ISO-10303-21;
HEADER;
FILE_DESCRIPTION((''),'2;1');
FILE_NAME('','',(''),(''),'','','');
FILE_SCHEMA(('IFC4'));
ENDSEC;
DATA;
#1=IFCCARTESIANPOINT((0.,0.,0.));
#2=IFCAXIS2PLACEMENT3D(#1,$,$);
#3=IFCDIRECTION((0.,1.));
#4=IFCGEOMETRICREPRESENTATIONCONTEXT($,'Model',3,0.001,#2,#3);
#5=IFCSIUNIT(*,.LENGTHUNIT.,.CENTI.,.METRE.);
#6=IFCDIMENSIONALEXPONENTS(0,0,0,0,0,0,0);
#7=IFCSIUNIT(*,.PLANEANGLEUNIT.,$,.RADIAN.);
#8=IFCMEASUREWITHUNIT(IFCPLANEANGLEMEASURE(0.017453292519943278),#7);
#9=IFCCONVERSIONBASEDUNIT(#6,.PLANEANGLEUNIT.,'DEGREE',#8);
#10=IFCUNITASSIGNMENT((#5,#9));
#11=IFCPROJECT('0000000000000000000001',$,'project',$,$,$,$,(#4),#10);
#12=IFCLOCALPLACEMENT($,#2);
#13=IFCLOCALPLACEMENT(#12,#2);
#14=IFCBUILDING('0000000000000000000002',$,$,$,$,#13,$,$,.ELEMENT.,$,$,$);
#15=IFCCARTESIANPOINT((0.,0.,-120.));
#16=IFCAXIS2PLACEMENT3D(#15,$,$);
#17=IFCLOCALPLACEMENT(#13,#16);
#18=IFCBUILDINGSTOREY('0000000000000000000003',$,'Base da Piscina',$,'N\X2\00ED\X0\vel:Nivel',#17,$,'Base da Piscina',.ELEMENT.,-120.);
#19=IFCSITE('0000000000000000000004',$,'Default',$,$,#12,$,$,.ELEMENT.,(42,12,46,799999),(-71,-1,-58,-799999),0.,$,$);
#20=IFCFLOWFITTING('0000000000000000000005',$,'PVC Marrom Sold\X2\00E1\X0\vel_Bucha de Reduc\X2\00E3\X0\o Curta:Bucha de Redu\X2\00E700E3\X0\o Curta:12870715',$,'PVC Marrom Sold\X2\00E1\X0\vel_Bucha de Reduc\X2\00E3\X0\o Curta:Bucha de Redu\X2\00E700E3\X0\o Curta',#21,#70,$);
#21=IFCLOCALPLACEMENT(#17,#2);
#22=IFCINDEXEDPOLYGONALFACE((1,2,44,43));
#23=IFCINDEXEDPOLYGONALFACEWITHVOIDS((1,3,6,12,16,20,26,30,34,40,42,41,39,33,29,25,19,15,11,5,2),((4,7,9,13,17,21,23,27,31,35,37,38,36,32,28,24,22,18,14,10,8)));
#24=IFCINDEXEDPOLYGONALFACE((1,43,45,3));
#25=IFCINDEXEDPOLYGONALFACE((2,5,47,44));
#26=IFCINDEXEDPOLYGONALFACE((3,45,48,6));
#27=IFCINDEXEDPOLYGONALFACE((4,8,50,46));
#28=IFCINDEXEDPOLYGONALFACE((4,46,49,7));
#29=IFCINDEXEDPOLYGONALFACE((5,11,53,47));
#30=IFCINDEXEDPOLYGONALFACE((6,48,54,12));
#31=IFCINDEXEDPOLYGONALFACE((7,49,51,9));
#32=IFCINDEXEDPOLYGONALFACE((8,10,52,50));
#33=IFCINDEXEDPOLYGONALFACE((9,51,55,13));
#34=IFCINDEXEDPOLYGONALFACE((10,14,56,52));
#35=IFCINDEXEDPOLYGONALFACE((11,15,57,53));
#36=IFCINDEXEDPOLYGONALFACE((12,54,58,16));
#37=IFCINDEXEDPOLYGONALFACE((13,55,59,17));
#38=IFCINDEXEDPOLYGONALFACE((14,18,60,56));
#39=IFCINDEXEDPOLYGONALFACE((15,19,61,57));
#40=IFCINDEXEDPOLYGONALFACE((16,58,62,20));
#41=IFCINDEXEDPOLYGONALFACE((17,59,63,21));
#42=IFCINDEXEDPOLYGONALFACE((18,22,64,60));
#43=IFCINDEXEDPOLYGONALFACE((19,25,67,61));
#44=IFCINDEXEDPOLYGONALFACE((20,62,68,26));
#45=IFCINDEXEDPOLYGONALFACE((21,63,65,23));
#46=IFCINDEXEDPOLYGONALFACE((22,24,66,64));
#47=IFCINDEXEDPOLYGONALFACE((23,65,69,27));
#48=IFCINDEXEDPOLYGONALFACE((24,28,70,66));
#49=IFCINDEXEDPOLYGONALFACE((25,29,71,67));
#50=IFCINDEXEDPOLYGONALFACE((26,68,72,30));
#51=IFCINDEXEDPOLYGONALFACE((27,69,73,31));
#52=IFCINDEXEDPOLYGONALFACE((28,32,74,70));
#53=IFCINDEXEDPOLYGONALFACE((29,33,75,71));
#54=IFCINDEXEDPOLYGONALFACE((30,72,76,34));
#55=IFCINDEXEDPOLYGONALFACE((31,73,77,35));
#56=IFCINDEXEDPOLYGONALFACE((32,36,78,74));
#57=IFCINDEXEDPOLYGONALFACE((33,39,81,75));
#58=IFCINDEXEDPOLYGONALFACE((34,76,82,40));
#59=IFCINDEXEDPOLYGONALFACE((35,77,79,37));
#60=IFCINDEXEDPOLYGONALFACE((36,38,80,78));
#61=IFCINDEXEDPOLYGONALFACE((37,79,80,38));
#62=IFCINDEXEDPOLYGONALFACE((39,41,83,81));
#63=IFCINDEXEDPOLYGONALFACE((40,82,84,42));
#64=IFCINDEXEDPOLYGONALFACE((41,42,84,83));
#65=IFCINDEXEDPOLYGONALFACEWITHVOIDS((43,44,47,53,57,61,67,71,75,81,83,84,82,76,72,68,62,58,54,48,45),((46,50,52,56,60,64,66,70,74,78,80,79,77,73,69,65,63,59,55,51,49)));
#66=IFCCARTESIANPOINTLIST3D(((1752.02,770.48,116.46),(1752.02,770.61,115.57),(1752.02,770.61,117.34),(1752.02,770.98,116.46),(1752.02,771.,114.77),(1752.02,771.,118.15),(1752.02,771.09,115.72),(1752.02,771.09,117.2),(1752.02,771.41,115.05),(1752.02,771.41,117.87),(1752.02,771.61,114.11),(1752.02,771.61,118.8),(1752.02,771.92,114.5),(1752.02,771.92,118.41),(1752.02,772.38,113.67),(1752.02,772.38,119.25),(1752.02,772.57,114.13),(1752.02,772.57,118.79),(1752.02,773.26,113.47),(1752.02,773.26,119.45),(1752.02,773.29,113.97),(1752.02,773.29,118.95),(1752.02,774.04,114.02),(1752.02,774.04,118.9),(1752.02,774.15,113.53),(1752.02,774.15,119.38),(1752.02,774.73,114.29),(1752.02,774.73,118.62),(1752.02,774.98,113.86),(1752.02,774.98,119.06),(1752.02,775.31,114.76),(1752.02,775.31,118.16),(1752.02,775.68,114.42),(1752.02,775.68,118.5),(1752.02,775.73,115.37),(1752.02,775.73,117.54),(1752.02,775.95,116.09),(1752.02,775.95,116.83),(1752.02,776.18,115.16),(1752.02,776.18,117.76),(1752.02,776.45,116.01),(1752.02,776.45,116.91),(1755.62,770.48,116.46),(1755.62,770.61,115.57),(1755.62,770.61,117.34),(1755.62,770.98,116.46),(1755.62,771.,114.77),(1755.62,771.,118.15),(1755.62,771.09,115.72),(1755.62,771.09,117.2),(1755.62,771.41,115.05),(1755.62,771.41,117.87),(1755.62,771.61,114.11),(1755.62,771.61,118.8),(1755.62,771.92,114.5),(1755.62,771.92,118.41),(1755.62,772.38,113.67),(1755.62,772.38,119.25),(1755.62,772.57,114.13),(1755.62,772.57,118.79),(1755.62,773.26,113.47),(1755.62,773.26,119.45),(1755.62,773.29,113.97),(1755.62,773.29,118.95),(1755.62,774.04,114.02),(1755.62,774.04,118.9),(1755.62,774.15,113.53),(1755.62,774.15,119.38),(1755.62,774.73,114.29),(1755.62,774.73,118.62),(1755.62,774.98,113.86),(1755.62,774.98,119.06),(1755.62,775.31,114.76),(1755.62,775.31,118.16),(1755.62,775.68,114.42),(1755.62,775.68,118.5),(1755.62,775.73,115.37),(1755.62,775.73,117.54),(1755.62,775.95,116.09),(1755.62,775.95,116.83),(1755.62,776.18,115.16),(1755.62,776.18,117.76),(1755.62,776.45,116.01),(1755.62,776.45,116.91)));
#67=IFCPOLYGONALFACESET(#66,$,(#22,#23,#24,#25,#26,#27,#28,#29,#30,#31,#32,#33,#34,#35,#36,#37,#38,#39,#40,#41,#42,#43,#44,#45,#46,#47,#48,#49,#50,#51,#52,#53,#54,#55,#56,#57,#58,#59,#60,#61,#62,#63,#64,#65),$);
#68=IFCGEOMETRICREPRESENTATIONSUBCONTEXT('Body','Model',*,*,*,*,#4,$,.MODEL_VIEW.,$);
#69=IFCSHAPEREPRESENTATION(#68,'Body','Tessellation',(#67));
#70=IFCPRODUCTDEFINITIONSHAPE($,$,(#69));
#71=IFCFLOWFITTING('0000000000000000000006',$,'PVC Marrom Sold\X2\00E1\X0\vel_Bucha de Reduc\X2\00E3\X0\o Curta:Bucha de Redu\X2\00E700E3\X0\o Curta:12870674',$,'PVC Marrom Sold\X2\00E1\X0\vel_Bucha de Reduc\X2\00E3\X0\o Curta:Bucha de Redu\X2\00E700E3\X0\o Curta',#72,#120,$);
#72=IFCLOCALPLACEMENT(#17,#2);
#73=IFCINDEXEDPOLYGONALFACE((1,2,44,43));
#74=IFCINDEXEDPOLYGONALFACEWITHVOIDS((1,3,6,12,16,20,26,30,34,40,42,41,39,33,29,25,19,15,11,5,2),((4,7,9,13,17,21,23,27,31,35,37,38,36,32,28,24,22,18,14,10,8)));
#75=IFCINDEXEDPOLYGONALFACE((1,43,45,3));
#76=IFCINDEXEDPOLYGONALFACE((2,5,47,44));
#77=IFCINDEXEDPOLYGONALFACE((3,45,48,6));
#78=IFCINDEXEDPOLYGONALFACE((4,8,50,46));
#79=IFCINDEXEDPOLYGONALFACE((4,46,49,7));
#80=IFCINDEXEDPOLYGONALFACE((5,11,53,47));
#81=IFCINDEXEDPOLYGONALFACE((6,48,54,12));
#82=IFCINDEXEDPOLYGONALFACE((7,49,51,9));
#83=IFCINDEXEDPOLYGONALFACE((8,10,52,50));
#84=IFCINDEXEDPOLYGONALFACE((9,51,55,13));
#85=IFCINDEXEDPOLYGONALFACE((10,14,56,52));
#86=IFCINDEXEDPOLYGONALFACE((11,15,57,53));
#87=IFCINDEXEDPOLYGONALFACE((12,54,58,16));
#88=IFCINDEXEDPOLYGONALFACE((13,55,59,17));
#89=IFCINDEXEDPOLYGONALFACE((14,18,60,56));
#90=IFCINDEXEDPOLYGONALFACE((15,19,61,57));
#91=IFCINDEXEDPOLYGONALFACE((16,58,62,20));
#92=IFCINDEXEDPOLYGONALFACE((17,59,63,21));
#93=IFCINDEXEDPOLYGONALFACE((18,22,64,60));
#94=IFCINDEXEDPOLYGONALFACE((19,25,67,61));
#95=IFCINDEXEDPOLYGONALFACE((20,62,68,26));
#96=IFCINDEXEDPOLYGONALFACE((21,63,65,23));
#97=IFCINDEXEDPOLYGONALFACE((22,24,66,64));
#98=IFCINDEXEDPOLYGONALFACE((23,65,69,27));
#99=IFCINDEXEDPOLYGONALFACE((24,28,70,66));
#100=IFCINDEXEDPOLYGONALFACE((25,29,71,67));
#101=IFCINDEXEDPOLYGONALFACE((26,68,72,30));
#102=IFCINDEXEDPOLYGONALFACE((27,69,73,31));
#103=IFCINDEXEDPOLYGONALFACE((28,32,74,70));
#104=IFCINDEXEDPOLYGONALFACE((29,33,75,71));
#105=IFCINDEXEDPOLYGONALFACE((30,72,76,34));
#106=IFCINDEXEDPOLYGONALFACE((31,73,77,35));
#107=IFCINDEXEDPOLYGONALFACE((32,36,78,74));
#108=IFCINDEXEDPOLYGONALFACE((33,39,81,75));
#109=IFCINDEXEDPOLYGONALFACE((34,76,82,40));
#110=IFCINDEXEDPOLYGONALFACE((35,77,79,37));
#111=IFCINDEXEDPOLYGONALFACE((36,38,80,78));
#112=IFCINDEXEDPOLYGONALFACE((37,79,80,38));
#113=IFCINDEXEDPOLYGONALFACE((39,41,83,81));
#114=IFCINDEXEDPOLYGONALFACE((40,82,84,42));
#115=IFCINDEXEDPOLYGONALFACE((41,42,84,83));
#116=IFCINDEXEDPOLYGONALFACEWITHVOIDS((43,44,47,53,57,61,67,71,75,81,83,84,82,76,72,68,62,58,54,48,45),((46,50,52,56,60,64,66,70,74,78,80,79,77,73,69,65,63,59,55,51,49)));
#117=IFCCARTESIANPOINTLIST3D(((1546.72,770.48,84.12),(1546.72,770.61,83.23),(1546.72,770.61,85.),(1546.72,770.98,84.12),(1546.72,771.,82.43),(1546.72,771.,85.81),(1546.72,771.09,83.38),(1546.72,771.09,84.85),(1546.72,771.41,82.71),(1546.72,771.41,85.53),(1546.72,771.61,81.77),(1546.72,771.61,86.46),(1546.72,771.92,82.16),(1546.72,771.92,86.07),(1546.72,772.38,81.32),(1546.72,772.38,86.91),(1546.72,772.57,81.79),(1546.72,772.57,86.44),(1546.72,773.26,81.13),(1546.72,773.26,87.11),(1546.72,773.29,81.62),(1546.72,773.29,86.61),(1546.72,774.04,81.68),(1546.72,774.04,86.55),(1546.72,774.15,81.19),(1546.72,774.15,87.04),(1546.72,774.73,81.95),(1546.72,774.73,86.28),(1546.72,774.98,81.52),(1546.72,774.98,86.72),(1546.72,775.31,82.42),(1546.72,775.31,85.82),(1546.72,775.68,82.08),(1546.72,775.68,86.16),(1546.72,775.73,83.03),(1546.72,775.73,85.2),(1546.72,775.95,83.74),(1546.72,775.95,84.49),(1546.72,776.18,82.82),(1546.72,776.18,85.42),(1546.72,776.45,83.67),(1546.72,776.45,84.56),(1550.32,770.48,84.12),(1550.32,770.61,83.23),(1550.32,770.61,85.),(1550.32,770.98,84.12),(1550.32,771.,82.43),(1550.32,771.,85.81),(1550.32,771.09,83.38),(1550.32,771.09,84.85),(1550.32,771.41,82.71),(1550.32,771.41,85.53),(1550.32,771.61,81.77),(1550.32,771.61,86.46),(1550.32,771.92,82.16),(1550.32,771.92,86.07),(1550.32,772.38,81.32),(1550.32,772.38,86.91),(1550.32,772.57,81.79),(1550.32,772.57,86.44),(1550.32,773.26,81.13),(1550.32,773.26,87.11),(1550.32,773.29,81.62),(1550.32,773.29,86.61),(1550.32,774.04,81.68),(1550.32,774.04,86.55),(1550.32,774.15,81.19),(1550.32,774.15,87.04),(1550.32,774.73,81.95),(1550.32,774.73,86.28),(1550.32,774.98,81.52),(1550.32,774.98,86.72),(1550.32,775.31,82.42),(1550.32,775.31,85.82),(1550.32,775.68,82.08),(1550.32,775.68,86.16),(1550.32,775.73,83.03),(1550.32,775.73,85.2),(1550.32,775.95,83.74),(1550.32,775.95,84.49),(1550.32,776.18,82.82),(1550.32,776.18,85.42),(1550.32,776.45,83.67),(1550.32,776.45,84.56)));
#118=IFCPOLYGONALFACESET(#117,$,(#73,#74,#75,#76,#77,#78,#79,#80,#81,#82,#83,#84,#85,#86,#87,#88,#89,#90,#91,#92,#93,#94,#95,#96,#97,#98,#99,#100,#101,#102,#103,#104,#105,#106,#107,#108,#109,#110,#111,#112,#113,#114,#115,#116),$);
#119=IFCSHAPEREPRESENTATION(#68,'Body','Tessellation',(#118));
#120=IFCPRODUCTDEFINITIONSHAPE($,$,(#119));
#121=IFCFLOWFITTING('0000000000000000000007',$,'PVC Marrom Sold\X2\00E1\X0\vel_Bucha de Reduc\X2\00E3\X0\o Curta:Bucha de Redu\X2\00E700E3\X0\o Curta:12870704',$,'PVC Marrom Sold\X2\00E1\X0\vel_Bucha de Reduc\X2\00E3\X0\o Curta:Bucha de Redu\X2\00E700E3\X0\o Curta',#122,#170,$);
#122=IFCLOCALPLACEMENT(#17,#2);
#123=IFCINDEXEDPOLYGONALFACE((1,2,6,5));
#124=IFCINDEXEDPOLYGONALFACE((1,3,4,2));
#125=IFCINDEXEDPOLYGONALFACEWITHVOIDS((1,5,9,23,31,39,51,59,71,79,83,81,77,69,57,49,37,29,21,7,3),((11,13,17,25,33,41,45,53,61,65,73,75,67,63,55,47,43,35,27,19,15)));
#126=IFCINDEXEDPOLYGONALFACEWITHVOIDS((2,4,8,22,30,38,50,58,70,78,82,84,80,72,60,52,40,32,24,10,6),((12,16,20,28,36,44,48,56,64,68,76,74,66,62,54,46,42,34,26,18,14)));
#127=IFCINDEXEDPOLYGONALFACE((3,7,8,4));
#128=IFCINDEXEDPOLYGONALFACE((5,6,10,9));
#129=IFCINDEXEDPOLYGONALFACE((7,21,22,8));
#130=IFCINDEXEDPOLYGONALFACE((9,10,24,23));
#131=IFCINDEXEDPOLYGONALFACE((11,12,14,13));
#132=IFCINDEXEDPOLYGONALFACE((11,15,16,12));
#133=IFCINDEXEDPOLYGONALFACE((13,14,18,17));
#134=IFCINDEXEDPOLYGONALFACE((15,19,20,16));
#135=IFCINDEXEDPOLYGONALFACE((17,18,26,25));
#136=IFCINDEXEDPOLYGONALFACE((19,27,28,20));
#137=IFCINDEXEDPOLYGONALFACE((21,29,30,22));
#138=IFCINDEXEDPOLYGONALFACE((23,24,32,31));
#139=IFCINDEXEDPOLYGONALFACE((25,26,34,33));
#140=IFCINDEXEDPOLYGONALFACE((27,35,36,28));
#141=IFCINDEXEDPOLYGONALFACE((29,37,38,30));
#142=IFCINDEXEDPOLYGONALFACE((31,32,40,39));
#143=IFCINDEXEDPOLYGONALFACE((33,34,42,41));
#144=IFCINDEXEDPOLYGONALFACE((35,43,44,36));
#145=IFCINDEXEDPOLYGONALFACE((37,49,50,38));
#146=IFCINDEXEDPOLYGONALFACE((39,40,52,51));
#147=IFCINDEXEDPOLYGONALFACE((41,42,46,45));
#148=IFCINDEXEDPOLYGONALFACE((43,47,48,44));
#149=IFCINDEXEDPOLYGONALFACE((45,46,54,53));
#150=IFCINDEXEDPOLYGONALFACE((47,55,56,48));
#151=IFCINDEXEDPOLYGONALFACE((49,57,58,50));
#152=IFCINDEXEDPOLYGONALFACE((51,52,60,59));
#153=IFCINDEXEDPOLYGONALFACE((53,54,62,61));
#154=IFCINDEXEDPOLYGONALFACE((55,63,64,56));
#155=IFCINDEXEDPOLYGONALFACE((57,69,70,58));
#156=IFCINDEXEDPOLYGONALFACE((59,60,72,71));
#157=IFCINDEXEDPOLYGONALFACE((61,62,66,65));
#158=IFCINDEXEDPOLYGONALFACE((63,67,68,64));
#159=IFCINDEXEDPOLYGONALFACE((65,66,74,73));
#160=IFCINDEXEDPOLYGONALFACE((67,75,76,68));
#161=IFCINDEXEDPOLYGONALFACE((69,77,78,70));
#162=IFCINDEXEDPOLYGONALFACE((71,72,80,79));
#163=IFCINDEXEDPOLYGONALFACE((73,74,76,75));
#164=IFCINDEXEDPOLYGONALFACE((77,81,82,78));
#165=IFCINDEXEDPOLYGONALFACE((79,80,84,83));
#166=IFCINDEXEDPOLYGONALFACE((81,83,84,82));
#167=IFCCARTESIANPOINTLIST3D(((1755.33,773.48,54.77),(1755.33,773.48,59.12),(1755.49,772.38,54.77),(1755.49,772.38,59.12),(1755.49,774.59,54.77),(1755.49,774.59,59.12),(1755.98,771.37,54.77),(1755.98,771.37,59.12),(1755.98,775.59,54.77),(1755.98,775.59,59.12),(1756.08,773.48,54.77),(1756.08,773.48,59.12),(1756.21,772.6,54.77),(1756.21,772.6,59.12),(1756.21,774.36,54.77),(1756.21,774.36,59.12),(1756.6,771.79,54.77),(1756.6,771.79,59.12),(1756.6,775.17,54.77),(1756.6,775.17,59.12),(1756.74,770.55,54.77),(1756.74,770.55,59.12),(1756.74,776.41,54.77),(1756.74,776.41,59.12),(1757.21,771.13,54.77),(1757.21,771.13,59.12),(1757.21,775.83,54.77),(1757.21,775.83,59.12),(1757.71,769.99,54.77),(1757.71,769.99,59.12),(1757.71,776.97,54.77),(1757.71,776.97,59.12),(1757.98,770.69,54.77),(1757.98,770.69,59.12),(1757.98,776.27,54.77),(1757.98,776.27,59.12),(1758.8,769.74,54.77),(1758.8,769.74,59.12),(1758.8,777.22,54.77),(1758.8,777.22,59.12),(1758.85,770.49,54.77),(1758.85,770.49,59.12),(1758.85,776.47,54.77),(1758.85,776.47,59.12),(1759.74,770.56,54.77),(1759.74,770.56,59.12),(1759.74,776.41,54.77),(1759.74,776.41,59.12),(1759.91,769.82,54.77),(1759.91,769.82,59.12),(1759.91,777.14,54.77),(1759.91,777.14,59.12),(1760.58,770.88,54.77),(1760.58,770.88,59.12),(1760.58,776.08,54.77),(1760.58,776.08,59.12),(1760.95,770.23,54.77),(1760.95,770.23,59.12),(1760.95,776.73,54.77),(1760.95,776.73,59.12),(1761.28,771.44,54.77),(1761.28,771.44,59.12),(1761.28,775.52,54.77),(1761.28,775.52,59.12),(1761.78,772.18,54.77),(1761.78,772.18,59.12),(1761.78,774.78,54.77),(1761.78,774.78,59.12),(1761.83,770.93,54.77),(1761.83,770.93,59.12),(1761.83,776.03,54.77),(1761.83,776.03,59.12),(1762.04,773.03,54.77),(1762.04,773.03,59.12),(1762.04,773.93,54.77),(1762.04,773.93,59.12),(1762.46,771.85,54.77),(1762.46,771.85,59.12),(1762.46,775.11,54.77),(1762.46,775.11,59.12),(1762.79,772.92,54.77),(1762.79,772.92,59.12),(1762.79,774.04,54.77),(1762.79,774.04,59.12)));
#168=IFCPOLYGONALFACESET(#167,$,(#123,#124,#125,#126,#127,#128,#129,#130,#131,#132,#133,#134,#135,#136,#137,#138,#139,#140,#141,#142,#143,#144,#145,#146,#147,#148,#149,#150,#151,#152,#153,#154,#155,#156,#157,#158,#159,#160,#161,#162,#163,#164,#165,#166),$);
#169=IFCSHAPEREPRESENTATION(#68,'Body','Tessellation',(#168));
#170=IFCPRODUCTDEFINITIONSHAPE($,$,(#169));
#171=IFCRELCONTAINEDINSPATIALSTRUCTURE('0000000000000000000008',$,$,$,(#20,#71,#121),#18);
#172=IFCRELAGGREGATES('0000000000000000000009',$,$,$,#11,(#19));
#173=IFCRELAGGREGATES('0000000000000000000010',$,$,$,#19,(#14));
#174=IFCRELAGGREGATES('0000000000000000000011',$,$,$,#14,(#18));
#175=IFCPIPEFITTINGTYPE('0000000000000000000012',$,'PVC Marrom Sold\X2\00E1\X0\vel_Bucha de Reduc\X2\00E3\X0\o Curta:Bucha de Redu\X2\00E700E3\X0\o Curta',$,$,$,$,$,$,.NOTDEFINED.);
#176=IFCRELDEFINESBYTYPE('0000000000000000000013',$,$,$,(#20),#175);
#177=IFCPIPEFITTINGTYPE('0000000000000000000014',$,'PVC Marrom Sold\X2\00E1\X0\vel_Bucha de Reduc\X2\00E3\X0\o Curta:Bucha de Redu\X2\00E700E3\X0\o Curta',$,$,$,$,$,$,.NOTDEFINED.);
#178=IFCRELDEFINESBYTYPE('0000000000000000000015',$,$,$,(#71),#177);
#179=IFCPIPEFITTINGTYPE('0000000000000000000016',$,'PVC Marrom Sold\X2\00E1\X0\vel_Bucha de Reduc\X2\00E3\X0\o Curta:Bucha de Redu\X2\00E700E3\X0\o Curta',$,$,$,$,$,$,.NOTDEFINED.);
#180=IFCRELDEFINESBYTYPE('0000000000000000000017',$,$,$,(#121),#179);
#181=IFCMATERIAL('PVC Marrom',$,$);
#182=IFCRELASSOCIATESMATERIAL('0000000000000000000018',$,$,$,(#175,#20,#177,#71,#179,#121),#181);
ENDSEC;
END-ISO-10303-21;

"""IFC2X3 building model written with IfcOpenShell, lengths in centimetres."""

from ifc_helpers import new_model, entity, si_unit, converted_unit, direction, frame, frame_2d, origin, place, context, subcontext, project, spatial, hollow_circle, extrude, source, transform, mapped, material, type_object, type_shapes, element, save


model = new_model("IFC2X3")

# Units and contexts
model_context = context("Model", 3, precision=0.001, world=origin(), true_north=direction((0.0, 1.0)))
body_context = subcontext(model_context, "Body", "Model", "MODEL_VIEW")
ifc_project = project(units=[si_unit("LENGTHUNIT", "METRE", prefix="CENTI"), converted_unit("PLANEANGLEUNIT", "DEGREE", entity("IfcPlaneAngleMeasure", 0.017453292519943278), si_unit("PLANEANGLEUNIT", "RADIAN"), dimensions=[0, 0, 0, 0, 0, 0, 0])], contexts=[model_context])

# Site, building, storey
site_placement = place(None, origin())
site = spatial("IfcSite", under=ifc_project, at=site_placement, Name="Default", CompositionType="ELEMENT", RefLatitude=(42, 12, 46, 799999), RefLongitude=(-71, -1, -58, -799999), RefElevation=0.0)
building_placement = place(site_placement, origin())
building = spatial("IfcBuilding", under=site, at=building_placement, CompositionType="ELEMENT")
storey_placement = place(building_placement, frame((0.0, 0.0, -120.0)))
storey = spatial("IfcBuildingStorey", under=building, at=storey_placement, Name="Base da Piscina", ObjectType="Nível:Nivel", LongName="Base da Piscina", CompositionType="ELEMENT", Elevation=-120.0)

# Flow fittings
ifc_material_1 = material(Name="PVC Marrom")
pipe_fitting_type_1 = type_object("IfcPipeFittingType", Name="PVC Marrom Soldável_Bucha de Reducão Curta:Bucha de Redução Curta", PredefinedType="NOTDEFINED", material=ifc_material_1)
shared_shape_1 = source(origin(), body_context, "Body", "SweptSolid", [
    extrude(hollow_circle(Radius=3.0, WallThickness=0.5, at=frame_2d((0.0, 0.0), x_axis=(1.0, 0.0))), frame((0.0, 0.0, 0.0), z_axis=(1.0, 0.0, 0.0), x_axis=(0.0, 1.0, 0.0)), (0.0, 0.0, 1.0), 3.6),
])
type_shapes(pipe_fitting_type_1, [shared_shape_1])
for number, where, z_axis, x_axis, name in (
    (1, (1755.62, 773.48, 116.46), (0.0, 0.0, 1.0), (-1.0, 0.0, 0.0), "PVC Marrom Soldável_Bucha de Reducão Curta:Bucha de Redução Curta:12870715"),
):
    element("IfcFlowFitting", number, at=place(storey_placement, frame(where, z_axis=z_axis, x_axis=x_axis)), inside=storey, type_object=pipe_fitting_type_1, material=ifc_material_1, Name=name, ObjectType="PVC Marrom Soldável_Bucha de Reducão Curta:Bucha de Redução Curta", context=body_context, shape_type="MappedRepresentation", body=[
        mapped(shared_shape_1, transform((0.0, 0.0, 0.0), scale=1.0)),
    ])
pipe_fitting_type_2 = type_object("IfcPipeFittingType", Name="PVC Marrom Soldável_Bucha de Reducão Curta:Bucha de Redução Curta", PredefinedType="NOTDEFINED", material=ifc_material_1)
shared_shape_2 = source(origin(), body_context, "Body", "SweptSolid", [
    extrude(hollow_circle(Radius=3.0, WallThickness=0.5, at=frame_2d((0.0, 0.0), x_axis=(1.0, 0.0))), frame((0.0, 0.0, 0.0), z_axis=(1.0, 0.0, 0.0), x_axis=(0.0, -1.0, 0.0)), (0.0, 0.0, 1.0), 3.6),
])
type_shapes(pipe_fitting_type_2, [shared_shape_2])
flow_fitting_1_placement = place(storey_placement, frame((1546.72, 773.48, 84.12)))
element("IfcFlowFitting", 2, at=flow_fitting_1_placement, inside=storey, type_object=pipe_fitting_type_2, material=ifc_material_1, Name="PVC Marrom Soldável_Bucha de Reducão Curta:Bucha de Redução Curta:12870674", ObjectType="PVC Marrom Soldável_Bucha de Reducão Curta:Bucha de Redução Curta", context=body_context, shape_type="MappedRepresentation", body=[
    mapped(shared_shape_2, transform((0.0, 0.0, 0.0), scale=1.0)),
])
pipe_fitting_type_3 = type_object("IfcPipeFittingType", Name="PVC Marrom Soldável_Bucha de Reducão Curta:Bucha de Redução Curta", PredefinedType="NOTDEFINED", material=ifc_material_1)
shared_shape_3 = source(origin(), body_context, "Body", "SweptSolid", [
    extrude(hollow_circle(Radius=3.75, WallThickness=0.75, at=frame_2d((0.0, 0.0), x_axis=(1.0, 0.0))), frame((0.0, 0.0, 0.0), z_axis=(1.0, 0.0, 0.0), x_axis=(0.0, -1.0, 0.0)), (0.0, 0.0, 1.0), 4.35),
])
type_shapes(pipe_fitting_type_3, [shared_shape_3])
flow_fitting_2_placement = place(storey_placement, frame((1759.08, 773.48, 54.77), z_axis=(0.0, 1.0, 0.0), x_axis=(0.0, 0.0, 1.0)))
element("IfcFlowFitting", 3, at=flow_fitting_2_placement, inside=storey, type_object=pipe_fitting_type_3, material=ifc_material_1, Name="PVC Marrom Soldável_Bucha de Reducão Curta:Bucha de Redução Curta:12870704", ObjectType="PVC Marrom Soldável_Bucha de Reducão Curta:Bucha de Redução Curta", context=body_context, shape_type="MappedRepresentation", body=[
    mapped(shared_shape_3, transform((0.0, 0.0, 0.0), scale=1.0)),
])

save(model, "model.ifc")
